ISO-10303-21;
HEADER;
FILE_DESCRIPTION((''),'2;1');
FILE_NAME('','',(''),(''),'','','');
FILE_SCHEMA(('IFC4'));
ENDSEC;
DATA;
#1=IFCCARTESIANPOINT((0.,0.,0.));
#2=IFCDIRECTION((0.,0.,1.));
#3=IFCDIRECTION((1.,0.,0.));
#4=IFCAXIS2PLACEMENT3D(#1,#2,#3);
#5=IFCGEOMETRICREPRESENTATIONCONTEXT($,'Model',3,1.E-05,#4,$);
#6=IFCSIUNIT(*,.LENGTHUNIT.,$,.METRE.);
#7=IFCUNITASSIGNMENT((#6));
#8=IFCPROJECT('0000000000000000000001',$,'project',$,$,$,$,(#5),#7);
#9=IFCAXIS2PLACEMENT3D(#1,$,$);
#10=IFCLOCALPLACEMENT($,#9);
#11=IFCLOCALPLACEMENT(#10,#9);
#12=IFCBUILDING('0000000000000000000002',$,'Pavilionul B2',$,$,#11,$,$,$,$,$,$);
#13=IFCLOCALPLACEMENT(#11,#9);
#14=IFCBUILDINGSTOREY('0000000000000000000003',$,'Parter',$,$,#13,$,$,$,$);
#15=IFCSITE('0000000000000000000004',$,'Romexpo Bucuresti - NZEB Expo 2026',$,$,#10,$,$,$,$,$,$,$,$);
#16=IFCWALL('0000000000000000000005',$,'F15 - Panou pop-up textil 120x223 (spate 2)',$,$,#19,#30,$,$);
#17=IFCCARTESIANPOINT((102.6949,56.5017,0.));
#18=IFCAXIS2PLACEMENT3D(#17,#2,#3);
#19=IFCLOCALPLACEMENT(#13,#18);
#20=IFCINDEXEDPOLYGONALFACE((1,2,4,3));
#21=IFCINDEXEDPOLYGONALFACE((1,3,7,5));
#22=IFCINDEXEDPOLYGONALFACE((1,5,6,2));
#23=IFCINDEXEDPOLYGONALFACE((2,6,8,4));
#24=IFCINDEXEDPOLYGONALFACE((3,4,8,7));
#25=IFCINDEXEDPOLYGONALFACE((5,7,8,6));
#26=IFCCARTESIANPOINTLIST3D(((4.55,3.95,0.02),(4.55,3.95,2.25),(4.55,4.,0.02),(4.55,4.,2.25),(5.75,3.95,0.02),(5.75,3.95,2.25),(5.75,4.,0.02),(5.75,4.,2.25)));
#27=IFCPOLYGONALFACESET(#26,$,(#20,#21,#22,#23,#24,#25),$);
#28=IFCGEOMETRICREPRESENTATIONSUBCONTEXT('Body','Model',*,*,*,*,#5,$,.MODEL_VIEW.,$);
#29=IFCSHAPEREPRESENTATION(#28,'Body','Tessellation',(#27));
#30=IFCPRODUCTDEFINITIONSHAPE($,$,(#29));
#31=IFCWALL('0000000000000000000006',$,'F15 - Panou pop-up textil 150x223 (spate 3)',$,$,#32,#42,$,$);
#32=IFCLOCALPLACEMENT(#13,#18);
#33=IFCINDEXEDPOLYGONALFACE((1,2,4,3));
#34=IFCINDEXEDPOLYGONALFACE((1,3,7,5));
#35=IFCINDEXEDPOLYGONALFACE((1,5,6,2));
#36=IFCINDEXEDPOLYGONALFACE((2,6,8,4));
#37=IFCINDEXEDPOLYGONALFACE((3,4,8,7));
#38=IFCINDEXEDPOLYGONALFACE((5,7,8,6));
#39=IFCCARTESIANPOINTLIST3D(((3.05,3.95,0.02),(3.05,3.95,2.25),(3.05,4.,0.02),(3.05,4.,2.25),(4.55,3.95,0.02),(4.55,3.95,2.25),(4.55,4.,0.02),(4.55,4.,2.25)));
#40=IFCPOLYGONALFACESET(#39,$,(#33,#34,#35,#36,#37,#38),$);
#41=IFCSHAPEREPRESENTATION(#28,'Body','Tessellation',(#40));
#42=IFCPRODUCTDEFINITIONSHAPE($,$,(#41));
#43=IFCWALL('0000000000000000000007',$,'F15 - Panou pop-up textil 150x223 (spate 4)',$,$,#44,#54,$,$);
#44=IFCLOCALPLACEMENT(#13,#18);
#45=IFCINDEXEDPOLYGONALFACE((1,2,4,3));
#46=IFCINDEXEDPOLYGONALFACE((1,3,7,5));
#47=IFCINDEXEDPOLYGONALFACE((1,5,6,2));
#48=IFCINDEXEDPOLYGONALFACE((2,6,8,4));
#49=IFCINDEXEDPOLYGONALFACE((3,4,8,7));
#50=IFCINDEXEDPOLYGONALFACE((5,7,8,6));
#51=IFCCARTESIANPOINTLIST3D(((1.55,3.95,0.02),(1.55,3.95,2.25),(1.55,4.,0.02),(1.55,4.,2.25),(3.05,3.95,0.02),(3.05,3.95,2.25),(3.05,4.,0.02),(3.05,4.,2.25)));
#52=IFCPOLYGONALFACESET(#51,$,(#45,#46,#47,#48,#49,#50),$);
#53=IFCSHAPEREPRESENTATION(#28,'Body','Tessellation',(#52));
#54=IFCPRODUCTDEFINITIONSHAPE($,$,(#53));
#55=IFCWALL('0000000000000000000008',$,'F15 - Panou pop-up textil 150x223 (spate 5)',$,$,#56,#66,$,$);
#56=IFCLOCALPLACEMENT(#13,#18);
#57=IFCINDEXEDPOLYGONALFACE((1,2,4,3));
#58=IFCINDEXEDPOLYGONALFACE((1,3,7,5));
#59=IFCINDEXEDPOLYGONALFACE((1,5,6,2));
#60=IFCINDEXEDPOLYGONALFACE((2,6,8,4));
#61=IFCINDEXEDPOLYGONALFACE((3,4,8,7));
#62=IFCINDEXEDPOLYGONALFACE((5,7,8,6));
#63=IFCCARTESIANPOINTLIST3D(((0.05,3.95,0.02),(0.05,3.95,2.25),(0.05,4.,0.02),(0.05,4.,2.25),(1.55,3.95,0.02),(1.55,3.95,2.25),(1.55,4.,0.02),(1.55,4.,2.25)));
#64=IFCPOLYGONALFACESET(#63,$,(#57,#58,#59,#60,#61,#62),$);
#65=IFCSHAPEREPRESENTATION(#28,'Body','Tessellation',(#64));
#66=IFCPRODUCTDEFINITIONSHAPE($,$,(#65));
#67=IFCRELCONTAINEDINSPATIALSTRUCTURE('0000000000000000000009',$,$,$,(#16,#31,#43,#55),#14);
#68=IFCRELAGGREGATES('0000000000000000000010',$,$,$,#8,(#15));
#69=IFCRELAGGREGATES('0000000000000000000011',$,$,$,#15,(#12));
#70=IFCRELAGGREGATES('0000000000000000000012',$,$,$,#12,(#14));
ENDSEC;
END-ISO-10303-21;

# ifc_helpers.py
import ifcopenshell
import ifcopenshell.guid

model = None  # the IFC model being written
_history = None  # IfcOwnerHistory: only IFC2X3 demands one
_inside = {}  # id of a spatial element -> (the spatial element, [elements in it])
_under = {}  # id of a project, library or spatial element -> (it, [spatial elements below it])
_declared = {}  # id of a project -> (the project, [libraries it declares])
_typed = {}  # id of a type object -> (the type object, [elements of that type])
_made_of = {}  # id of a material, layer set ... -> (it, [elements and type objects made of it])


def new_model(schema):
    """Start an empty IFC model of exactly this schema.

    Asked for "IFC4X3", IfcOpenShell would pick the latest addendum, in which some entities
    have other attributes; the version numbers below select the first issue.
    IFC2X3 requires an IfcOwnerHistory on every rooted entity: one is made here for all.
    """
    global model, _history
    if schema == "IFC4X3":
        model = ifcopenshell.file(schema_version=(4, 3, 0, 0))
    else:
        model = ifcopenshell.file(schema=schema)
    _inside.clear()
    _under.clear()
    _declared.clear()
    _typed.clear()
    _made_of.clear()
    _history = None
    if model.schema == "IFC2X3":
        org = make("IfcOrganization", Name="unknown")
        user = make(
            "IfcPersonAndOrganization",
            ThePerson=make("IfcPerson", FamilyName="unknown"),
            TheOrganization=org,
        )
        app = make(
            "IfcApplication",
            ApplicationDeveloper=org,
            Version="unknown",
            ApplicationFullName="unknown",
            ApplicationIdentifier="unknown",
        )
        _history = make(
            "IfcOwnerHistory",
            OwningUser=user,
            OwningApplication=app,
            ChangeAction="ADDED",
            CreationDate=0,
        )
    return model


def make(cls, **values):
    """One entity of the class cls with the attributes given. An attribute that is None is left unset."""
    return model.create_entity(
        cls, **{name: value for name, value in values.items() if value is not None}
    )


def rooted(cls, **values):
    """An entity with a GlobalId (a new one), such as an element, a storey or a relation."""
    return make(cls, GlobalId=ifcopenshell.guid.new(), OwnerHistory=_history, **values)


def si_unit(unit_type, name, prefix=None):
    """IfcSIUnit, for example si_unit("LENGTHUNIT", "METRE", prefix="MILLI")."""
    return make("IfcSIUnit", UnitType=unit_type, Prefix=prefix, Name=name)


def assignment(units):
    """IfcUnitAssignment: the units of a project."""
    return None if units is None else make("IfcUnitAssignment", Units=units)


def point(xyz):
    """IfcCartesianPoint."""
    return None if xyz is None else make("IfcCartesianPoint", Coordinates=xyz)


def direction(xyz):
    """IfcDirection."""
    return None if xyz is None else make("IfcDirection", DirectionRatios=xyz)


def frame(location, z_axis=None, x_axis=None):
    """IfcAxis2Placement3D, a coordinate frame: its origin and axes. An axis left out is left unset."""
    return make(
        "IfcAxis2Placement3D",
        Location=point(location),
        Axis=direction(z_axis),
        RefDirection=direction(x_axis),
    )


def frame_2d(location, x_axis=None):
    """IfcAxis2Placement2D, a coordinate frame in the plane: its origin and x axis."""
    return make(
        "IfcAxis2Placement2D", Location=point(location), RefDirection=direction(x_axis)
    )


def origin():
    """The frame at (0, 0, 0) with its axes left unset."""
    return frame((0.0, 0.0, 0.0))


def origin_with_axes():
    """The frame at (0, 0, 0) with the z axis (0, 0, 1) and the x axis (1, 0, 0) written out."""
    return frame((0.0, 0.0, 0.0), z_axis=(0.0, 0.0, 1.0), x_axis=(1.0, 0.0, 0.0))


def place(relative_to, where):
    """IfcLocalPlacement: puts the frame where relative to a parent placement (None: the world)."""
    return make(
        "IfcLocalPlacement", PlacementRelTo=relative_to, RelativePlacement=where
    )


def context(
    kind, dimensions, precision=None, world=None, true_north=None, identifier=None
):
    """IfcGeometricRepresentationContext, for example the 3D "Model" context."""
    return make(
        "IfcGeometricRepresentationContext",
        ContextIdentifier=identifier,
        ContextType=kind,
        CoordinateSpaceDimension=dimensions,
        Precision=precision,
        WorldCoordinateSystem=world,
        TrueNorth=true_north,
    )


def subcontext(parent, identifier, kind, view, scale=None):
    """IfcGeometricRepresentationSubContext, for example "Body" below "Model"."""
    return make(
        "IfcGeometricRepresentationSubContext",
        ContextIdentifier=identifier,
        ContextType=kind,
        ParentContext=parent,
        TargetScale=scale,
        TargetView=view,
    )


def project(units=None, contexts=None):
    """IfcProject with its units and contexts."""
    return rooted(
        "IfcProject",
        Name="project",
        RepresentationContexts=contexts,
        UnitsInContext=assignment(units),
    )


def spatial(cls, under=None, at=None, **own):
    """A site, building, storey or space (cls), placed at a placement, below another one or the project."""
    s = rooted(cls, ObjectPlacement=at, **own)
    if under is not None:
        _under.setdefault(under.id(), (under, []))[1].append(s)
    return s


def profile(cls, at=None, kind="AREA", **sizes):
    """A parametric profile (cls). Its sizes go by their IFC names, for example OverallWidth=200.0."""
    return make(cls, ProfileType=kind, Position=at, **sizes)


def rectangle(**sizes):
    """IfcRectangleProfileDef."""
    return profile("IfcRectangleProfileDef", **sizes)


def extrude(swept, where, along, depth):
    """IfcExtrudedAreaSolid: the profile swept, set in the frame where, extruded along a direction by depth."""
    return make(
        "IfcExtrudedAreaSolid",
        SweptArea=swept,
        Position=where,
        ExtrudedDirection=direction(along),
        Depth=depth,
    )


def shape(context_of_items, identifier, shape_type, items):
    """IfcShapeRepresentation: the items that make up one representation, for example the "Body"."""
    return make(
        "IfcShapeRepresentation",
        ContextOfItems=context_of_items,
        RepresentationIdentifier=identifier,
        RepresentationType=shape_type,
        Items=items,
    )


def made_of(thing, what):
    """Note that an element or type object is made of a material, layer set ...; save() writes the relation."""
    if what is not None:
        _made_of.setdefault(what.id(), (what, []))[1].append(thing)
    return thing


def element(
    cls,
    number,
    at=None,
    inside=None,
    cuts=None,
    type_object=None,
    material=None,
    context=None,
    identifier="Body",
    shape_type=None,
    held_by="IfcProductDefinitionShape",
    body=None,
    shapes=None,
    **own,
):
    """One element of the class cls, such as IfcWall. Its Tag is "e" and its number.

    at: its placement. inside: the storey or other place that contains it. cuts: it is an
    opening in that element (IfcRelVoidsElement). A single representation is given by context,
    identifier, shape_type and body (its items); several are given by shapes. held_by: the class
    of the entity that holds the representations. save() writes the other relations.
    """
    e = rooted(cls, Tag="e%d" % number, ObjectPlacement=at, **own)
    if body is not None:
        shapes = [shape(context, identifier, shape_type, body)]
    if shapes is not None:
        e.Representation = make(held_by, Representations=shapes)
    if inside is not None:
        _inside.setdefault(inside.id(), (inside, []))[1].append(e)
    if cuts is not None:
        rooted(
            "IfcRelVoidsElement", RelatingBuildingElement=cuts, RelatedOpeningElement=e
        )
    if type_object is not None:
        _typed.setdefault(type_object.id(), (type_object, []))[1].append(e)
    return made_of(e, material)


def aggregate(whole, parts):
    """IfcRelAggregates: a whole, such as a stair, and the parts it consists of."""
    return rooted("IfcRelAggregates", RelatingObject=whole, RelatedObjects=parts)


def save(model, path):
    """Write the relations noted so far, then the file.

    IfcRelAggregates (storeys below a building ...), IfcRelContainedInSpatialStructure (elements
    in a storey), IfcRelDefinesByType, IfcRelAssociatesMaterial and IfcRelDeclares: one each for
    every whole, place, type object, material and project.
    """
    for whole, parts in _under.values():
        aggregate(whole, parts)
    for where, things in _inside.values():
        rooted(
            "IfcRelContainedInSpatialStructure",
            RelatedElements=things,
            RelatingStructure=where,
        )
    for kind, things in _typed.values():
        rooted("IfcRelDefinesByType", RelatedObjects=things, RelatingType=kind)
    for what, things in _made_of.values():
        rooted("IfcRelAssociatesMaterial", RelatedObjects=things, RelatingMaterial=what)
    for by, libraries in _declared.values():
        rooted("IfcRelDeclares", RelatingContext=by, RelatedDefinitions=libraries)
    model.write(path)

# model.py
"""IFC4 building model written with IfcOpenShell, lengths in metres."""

from ifc_helpers import new_model, si_unit, frame, frame_2d, origin, origin_with_axes, place, context, subcontext, project, spatial, rectangle, extrude, element, save


model = new_model("IFC4")

# Units and contexts
model_context = context("Model", 3, precision=1e-05, world=origin_with_axes())
body_context = subcontext(model_context, "Body", "Model", "MODEL_VIEW")
ifc_project = project(units=[si_unit("LENGTHUNIT", "METRE")], contexts=[model_context])

# Site, building, storey
site_placement = place(None, origin())
site = spatial("IfcSite", under=ifc_project, at=site_placement, Name="Romexpo Bucuresti - NZEB Expo 2026")
building_placement = place(site_placement, origin())
building = spatial("IfcBuilding", under=site, at=building_placement, Name="Pavilionul B2")
storey_placement = place(building_placement, origin())
storey = spatial("IfcBuildingStorey", under=building, at=storey_placement, Name="Parter")

# Walls
wall_1_placement = place(storey_placement, frame((102.6949, 56.5017, 0.0), z_axis=(0.0, 0.0, 1.0), x_axis=(1.0, 0.0, 0.0)))
element("IfcWall", 1, at=wall_1_placement, inside=storey, Name="F15 - Panou pop-up textil 120x223 (spate 2)", context=body_context, shape_type="SweptSolid", body=[
    extrude(rectangle(XDim=1.2, YDim=0.05, at=frame_2d((5.15, 3.975))), frame((0.0, 0.0, 0.02)), (0.0, 0.0, 1.0), 2.23),
])
wall_2_placement = place(storey_placement, frame((102.6949, 56.5017, 0.0), z_axis=(0.0, 0.0, 1.0), x_axis=(1.0, 0.0, 0.0)))
element("IfcWall", 2, at=wall_2_placement, inside=storey, Name="F15 - Panou pop-up textil 150x223 (spate 3)", context=body_context, shape_type="SweptSolid", body=[
    extrude(rectangle(XDim=1.5, YDim=0.05, at=frame_2d((3.8, 3.975))), frame((0.0, 0.0, 0.02)), (0.0, 0.0, 1.0), 2.23),
])
wall_3_placement = place(storey_placement, frame((102.6949, 56.5017, 0.0), z_axis=(0.0, 0.0, 1.0), x_axis=(1.0, 0.0, 0.0)))
element("IfcWall", 3, at=wall_3_placement, inside=storey, Name="F15 - Panou pop-up textil 150x223 (spate 4)", context=body_context, shape_type="SweptSolid", body=[
    extrude(rectangle(XDim=1.5, YDim=0.05, at=frame_2d((2.3, 3.975))), frame((0.0, 0.0, 0.02)), (0.0, 0.0, 1.0), 2.23),
])
wall_4_placement = place(storey_placement, frame((102.6949, 56.5017, 0.0), z_axis=(0.0, 0.0, 1.0), x_axis=(1.0, 0.0, 0.0)))
element("IfcWall", 4, at=wall_4_placement, inside=storey, Name="F15 - Panou pop-up textil 150x223 (spate 5)", context=body_context, shape_type="SweptSolid", body=[
    extrude(rectangle(XDim=1.5, YDim=0.05, at=frame_2d((0.8, 3.975))), frame((0.0, 0.0, 0.02)), (0.0, 0.0, 1.0), 2.23),
])

save(model, "model.ifc")
